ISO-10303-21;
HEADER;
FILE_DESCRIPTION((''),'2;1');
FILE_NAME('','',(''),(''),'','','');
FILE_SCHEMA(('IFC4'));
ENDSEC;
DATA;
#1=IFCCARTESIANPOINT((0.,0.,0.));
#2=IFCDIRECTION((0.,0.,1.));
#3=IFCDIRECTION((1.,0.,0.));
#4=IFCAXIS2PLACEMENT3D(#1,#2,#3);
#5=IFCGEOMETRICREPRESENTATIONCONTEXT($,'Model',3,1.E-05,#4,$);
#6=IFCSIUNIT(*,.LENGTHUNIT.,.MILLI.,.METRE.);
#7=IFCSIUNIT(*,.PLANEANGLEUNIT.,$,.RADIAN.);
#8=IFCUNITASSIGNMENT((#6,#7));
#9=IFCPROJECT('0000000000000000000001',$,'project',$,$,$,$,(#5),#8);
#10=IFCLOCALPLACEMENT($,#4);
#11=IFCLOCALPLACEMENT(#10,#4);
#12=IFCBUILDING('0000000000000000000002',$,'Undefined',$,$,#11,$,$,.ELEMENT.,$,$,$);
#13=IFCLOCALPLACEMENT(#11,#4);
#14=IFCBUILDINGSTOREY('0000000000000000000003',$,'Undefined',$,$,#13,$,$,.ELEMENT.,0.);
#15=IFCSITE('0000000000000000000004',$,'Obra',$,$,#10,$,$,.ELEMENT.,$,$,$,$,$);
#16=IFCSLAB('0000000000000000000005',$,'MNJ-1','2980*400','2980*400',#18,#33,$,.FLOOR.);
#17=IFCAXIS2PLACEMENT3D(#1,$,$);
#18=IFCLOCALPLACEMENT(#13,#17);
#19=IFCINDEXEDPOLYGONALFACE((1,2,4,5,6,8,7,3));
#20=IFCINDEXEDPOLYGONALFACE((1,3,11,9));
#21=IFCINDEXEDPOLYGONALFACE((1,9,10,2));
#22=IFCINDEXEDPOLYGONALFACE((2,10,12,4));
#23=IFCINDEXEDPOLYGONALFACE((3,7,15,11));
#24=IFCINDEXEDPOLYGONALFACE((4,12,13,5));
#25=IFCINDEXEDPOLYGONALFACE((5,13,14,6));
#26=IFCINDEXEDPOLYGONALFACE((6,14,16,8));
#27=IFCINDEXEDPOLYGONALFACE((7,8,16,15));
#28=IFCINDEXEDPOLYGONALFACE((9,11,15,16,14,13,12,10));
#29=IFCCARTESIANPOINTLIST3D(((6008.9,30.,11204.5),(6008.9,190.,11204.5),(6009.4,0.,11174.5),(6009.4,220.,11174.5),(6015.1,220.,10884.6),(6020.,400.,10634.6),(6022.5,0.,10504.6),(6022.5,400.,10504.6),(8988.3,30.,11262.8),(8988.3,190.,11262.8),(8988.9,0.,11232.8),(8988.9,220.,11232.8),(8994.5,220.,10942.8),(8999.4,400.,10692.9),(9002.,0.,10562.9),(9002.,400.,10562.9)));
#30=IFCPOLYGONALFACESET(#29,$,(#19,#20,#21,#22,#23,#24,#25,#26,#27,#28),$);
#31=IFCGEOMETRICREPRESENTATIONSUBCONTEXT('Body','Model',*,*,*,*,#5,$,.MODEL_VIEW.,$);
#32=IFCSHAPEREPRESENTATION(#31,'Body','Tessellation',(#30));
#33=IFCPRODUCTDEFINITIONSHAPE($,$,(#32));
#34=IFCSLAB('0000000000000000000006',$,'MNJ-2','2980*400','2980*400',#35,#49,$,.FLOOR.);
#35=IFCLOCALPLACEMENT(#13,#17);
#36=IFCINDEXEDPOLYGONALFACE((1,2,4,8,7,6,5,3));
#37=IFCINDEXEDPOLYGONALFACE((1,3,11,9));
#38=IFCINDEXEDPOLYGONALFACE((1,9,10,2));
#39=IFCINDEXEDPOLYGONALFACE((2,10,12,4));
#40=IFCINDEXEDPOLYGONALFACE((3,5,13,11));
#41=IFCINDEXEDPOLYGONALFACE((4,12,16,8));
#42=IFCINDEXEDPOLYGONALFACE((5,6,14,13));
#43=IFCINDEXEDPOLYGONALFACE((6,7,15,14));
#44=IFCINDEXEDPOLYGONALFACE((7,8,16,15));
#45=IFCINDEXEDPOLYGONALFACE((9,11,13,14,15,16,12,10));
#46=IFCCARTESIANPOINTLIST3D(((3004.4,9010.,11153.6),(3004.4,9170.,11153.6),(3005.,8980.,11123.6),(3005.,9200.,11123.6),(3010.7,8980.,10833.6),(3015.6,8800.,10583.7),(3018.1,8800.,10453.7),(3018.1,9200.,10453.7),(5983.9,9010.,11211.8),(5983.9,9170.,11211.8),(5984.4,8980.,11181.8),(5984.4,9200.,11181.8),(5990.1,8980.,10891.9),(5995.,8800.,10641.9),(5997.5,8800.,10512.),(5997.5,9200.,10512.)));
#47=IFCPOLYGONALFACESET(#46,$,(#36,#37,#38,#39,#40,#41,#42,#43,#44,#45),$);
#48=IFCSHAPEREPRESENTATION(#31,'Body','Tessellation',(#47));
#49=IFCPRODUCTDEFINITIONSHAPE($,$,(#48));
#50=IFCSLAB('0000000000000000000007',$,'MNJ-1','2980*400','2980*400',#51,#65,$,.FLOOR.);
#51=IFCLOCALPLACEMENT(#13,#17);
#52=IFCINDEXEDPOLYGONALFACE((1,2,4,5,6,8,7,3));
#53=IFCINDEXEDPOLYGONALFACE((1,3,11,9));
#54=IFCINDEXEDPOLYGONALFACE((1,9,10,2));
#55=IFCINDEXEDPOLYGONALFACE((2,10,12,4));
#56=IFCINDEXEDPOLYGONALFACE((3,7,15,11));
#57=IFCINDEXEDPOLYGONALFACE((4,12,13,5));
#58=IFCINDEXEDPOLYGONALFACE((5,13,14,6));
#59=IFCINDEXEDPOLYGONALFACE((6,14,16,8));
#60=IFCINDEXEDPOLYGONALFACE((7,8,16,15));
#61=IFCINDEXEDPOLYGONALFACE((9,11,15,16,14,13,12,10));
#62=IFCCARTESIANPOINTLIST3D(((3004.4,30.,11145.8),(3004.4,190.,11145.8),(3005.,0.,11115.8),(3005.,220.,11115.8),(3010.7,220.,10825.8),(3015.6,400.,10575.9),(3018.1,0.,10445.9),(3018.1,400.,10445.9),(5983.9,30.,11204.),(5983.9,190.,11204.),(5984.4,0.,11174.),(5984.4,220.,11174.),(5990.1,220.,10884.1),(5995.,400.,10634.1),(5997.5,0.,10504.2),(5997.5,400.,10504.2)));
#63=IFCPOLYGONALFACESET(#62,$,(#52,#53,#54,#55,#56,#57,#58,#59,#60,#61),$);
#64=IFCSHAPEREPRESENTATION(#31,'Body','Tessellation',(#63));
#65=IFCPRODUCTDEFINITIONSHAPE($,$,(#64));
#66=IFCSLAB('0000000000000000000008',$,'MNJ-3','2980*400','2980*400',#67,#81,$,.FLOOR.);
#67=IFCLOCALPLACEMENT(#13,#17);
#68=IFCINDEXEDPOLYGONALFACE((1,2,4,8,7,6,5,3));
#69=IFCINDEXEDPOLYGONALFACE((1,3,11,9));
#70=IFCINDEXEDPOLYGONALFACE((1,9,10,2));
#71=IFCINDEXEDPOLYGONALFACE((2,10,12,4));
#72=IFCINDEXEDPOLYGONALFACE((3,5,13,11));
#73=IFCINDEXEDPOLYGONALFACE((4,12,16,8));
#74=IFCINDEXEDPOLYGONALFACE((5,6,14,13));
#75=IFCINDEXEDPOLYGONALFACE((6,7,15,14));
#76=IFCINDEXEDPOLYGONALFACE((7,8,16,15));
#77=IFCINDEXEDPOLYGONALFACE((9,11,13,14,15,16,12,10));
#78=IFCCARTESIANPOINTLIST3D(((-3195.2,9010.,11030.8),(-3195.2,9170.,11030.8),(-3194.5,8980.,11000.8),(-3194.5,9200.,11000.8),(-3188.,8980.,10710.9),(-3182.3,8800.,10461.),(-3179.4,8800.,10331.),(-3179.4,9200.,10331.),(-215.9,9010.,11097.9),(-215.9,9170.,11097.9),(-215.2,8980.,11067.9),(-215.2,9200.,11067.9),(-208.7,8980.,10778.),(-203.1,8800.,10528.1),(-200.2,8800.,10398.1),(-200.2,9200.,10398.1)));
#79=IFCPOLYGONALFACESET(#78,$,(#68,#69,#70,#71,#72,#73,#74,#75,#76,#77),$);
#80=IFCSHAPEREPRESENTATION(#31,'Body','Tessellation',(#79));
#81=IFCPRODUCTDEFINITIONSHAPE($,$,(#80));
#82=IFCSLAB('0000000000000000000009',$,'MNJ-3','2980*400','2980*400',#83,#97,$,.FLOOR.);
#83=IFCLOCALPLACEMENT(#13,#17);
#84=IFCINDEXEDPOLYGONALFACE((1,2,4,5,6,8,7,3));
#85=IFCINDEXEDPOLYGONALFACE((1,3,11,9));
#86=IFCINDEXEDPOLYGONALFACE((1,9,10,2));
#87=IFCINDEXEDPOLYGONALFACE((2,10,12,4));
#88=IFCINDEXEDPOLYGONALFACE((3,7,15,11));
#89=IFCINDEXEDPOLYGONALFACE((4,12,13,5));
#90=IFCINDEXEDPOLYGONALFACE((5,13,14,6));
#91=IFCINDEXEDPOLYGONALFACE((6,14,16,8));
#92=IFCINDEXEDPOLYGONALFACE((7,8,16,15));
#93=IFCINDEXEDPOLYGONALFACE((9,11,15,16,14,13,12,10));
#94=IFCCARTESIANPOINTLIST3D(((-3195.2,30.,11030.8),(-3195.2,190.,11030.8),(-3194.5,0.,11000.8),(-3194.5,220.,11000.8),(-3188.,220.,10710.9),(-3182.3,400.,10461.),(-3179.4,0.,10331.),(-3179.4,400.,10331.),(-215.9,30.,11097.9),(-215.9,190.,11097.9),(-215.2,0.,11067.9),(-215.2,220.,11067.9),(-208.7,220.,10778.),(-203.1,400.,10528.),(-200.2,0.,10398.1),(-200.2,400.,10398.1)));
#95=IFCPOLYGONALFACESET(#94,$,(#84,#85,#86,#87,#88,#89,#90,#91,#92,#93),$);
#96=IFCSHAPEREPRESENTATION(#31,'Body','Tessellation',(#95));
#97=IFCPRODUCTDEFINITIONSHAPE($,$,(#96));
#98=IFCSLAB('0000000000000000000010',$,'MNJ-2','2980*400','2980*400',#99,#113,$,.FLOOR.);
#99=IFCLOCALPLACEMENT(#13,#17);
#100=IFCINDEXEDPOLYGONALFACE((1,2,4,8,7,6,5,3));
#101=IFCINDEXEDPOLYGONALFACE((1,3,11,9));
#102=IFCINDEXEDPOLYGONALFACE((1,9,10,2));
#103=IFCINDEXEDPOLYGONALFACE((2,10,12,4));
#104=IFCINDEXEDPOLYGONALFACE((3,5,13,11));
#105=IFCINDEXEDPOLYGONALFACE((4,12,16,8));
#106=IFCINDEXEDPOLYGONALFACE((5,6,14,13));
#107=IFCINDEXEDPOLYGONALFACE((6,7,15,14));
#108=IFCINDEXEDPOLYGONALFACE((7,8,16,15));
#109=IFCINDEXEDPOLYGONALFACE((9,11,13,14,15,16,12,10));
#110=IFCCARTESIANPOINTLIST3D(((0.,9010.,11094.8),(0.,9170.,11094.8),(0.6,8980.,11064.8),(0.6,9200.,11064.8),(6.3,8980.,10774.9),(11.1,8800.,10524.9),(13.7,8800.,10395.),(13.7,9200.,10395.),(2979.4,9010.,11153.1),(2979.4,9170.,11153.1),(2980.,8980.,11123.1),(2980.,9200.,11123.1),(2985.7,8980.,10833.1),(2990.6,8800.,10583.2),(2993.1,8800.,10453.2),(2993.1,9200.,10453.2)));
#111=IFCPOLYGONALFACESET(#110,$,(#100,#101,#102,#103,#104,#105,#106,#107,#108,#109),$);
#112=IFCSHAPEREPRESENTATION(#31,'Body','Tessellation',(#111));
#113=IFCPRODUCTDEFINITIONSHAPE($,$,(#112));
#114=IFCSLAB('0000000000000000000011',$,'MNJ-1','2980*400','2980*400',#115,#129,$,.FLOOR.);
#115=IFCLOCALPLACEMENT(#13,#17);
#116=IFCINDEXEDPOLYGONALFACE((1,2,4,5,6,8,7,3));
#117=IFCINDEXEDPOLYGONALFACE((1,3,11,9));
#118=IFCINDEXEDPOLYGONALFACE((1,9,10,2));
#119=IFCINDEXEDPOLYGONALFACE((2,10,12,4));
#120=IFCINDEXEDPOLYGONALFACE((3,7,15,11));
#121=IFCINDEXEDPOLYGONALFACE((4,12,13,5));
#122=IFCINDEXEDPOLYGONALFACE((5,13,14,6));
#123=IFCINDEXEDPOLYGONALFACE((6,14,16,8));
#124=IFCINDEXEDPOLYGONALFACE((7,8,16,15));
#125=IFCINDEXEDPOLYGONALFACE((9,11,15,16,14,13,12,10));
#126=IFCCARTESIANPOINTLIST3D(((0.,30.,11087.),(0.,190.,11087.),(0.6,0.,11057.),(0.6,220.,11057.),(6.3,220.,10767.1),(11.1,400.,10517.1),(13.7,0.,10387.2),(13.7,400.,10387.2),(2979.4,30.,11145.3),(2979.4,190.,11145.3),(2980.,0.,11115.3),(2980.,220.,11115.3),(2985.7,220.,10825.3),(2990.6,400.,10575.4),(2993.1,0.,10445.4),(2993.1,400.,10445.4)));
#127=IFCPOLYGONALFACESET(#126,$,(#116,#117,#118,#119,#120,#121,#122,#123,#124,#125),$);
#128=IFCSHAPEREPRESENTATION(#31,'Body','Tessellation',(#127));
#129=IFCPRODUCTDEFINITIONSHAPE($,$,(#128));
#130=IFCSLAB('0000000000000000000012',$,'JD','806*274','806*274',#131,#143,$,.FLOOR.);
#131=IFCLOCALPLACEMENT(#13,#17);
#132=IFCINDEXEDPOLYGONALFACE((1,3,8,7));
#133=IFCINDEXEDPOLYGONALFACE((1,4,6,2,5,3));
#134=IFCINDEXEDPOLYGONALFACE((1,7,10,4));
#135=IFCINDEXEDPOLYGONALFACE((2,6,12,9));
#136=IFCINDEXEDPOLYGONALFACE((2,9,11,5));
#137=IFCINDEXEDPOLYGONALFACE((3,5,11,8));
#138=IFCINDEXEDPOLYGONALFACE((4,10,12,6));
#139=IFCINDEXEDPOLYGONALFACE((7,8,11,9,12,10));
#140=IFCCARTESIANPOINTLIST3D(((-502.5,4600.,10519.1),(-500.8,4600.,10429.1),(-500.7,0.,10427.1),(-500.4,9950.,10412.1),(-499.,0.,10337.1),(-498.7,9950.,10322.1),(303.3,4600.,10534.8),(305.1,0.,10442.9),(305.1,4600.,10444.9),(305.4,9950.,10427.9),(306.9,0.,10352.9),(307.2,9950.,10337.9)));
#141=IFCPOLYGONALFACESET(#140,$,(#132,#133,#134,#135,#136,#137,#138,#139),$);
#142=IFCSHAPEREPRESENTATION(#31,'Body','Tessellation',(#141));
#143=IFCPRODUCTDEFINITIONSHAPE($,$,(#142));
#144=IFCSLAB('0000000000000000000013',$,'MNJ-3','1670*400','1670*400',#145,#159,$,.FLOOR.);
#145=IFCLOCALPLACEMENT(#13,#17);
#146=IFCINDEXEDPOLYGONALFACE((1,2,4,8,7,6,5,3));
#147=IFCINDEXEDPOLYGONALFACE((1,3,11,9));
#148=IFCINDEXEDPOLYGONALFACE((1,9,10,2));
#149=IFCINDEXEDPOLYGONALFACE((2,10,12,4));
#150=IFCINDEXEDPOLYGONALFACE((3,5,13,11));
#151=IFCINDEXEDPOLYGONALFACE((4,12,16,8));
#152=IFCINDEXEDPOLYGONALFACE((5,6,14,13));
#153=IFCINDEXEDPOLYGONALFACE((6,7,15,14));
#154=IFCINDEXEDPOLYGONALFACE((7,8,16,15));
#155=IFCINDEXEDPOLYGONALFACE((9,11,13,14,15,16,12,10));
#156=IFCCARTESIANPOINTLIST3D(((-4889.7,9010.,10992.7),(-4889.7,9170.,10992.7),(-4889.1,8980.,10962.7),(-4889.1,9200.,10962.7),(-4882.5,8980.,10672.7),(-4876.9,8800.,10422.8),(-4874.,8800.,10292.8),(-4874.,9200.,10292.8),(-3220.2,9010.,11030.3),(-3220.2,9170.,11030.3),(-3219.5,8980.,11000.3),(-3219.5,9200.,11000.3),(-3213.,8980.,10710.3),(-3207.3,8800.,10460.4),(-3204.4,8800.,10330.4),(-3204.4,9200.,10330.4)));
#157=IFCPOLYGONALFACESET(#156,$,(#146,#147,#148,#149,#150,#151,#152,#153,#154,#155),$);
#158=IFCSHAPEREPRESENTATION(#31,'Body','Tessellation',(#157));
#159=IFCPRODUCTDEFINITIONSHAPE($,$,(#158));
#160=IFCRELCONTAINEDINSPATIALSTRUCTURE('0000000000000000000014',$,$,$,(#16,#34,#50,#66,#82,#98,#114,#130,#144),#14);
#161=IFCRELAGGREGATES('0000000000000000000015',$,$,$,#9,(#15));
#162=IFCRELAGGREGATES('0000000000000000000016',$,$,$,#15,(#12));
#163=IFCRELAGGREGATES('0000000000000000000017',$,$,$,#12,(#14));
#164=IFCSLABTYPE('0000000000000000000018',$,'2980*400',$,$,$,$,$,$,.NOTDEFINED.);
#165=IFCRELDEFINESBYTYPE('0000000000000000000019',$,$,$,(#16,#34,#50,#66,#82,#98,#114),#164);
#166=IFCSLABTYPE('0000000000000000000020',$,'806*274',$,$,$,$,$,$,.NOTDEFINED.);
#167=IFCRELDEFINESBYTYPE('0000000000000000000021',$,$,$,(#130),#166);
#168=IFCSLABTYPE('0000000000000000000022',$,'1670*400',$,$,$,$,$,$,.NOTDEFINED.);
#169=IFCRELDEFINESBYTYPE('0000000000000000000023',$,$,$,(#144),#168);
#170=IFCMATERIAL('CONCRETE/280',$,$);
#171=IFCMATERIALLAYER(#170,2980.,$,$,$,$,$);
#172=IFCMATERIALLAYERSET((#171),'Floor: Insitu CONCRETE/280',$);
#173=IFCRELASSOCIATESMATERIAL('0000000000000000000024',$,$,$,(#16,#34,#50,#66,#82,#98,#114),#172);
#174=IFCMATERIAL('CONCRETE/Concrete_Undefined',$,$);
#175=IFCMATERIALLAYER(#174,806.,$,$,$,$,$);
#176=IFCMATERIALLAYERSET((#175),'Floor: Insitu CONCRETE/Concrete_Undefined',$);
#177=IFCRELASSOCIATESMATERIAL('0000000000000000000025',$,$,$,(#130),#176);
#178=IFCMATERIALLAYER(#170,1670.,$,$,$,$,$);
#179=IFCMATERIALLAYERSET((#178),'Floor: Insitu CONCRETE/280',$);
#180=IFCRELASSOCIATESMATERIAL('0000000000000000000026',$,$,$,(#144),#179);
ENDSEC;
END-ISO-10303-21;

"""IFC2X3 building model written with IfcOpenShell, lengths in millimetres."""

from ifc_helpers import new_model, si_unit, frame, origin_with_axes, place, context, subcontext, project, spatial, polyline, outline, extrude, material, layer, layer_set, layer_usage, type_object, element, save


model = new_model("IFC2X3")

# Units and contexts
model_context = context("Model", 3, precision=1e-05, world=origin_with_axes())
body_context = subcontext(model_context, "Body", "Model", "MODEL_VIEW")
ifc_project = project(units=[si_unit("LENGTHUNIT", "METRE", prefix="MILLI"), si_unit("PLANEANGLEUNIT", "RADIAN")], contexts=[model_context])

# Site, building, storey
site_placement = place(None, origin_with_axes())
site = spatial("IfcSite", under=ifc_project, at=site_placement, Name="Obra", CompositionType="ELEMENT")
building_placement = place(site_placement, origin_with_axes())
building = spatial("IfcBuilding", under=site, at=building_placement, Name="Undefined", CompositionType="ELEMENT")
storey_placement = place(building_placement, origin_with_axes())
storey = spatial("IfcBuildingStorey", under=building, at=storey_placement, Name="Undefined", CompositionType="ELEMENT", Elevation=0.0)

# Shared definitions
ifc_material_1 = material(Name="CONCRETE/280")

# Slabs
ifc_layer_1 = layer(ifc_material_1, 2980.0)
ifc_layer_set_1 = layer_set([ifc_layer_1], Name="Floor: Insitu CONCRETE/280")
slab_type_1 = type_object("IfcSlabType", Name="2980*400", PredefinedType="NOTDEFINED")
ifc_layer_usage_1 = layer_usage(ifc_layer_set_1, "AXIS3", "POSITIVE", -1490.0)
slab_1_placement = place(storey_placement, frame((7499.2, 0.0, 11203.6), z_axis=(0.999809, 0.0, 0.019547), x_axis=(0.019547, 0.0, -0.999809)))
element("IfcSlab", 1, at=slab_1_placement, inside=storey, type_object=slab_type_1, material=ifc_layer_usage_1, Name="MNJ-1", Description="2980*400", ObjectType="2980*400", PredefinedType="FLOOR", context=body_context, shape_type="SweptSolid", body=[
    extrude(outline(polyline([(0.0, 0.0), (670.0, 0.0), (670.0, 400.0), (540.0, 400.0), (290.0, 220.0), (0.0, 220.0), (-30.0, 190.0), (-30.0, 30.0), (0.0, 0.0)])), frame((0.0, 0.0, -1490.0), z_axis=(0.0, 0.0, 1.0), x_axis=(1.0, 0.0, 0.0)), (0.0, 0.0, 1.0), 2980.0),
])
ifc_layer_usage_2 = layer_usage(ifc_layer_set_1, "AXIS3", "POSITIVE", -1490.0)
slab_2_placement = place(storey_placement, frame((4494.7, 9200.0, 11152.7), z_axis=(-0.999809, 0.0, -0.019547), x_axis=(0.019547, 0.0, -0.999809)))
element("IfcSlab", 2, at=slab_2_placement, inside=storey, type_object=slab_type_1, material=ifc_layer_usage_2, Name="MNJ-2", Description="2980*400", ObjectType="2980*400", PredefinedType="FLOOR", context=body_context, shape_type="SweptSolid", body=[
    extrude(outline(polyline([(0.0, 0.0), (670.0, 0.0), (670.0, 400.0), (540.0, 400.0), (290.0, 220.0), (0.0, 220.0), (-30.0, 190.0), (-30.0, 30.0), (0.0, 0.0)])), frame((0.0, 0.0, -1490.0), z_axis=(0.0, 0.0, 1.0), x_axis=(1.0, 0.0, 0.0)), (0.0, 0.0, 1.0), 2980.0),
])
ifc_layer_usage_3 = layer_usage(ifc_layer_set_1, "AXIS3", "POSITIVE", -1490.0)
slab_3_placement = place(storey_placement, frame((4494.7, 0.0, 11144.9), z_axis=(0.999809, 0.0, 0.019547), x_axis=(0.019547, 0.0, -0.999809)))
element("IfcSlab", 3, at=slab_3_placement, inside=storey, type_object=slab_type_1, material=ifc_layer_usage_3, Name="MNJ-1", Description="2980*400", ObjectType="2980*400", PredefinedType="FLOOR", context=body_context, shape_type="SweptSolid", body=[
    extrude(outline(polyline([(0.0, 0.0), (670.0, 0.0), (670.0, 400.0), (540.0, 400.0), (290.0, 220.0), (0.0, 220.0), (-30.0, 190.0), (-30.0, 30.0), (0.0, 0.0)])), frame((0.0, 0.0, -1490.0), z_axis=(0.0, 0.0, 1.0), x_axis=(1.0, 0.0, 0.0)), (0.0, 0.0, 1.0), 2980.0),
])
ifc_layer_usage_4 = layer_usage(ifc_layer_set_1, "AXIS3", "POSITIVE", -1490.0)
slab_4_placement = place(storey_placement, frame((-1704.9, 9200.0, 11034.4), z_axis=(-0.999747, 0.0, -0.022513), x_axis=(0.022513, 0.0, -0.999747)))
element("IfcSlab", 4, at=slab_4_placement, inside=storey, type_object=slab_type_1, material=ifc_layer_usage_4, Name="MNJ-3", Description="2980*400", ObjectType="2980*400", PredefinedType="FLOOR", context=body_context, shape_type="SweptSolid", body=[
    extrude(outline(polyline([(0.0, 0.0), (670.0, 0.0), (670.0, 400.0), (540.0, 400.0), (290.0, 220.0), (0.0, 220.0), (-30.0, 190.0), (-30.0, 30.0), (0.0, 0.0)])), frame((0.0, 0.0, -1490.0), z_axis=(0.0, 0.0, 1.0), x_axis=(1.0, 0.0, 0.0)), (0.0, 0.0, 1.0), 2980.0),
])
ifc_layer_usage_5 = layer_usage(ifc_layer_set_1, "AXIS3", "POSITIVE", -1490.0)
slab_5_placement = place(storey_placement, frame((-1704.9, 0.0, 11034.4), z_axis=(0.999747, 0.0, 0.022513), x_axis=(0.022513, 0.0, -0.999747)))
element("IfcSlab", 5, at=slab_5_placement, inside=storey, type_object=slab_type_1, material=ifc_layer_usage_5, Name="MNJ-3", Description="2980*400", ObjectType="2980*400", PredefinedType="FLOOR", context=body_context, shape_type="SweptSolid", body=[
    extrude(outline(polyline([(0.0, 0.0), (670.0, 0.0), (670.0, 400.0), (540.0, 400.0), (290.0, 220.0), (0.0, 220.0), (-30.0, 190.0), (-30.0, 30.0), (0.0, 0.0)])), frame((0.0, 0.0, -1490.0), z_axis=(0.0, 0.0, 1.0), x_axis=(1.0, 0.0, 0.0)), (0.0, 0.0, 1.0), 2980.0),
])
ifc_layer_usage_6 = layer_usage(ifc_layer_set_1, "AXIS3", "POSITIVE", -1490.0)
slab_6_placement = place(storey_placement, frame((1490.3, 9200.0, 11094.0), z_axis=(-0.999809, 0.0, -0.019547), x_axis=(0.019547, 0.0, -0.999809)))
element("IfcSlab", 6, at=slab_6_placement, inside=storey, type_object=slab_type_1, material=ifc_layer_usage_6, Name="MNJ-2", Description="2980*400", ObjectType="2980*400", PredefinedType="FLOOR", context=body_context, shape_type="SweptSolid", body=[
    extrude(outline(polyline([(0.0, 0.0), (670.0, 0.0), (670.0, 400.0), (540.0, 400.0), (290.0, 220.0), (0.0, 220.0), (-30.0, 190.0), (-30.0, 30.0), (0.0, 0.0)])), frame((0.0, 0.0, -1490.0), z_axis=(0.0, 0.0, 1.0), x_axis=(1.0, 0.0, 0.0)), (0.0, 0.0, 1.0), 2980.0),
])
ifc_layer_usage_7 = layer_usage(ifc_layer_set_1, "AXIS3", "POSITIVE", -1490.0)
slab_7_placement = place(storey_placement, frame((1490.3, 0.0, 11086.2), z_axis=(0.999809, 0.0, 0.019547), x_axis=(0.019547, 0.0, -0.999809)))
element("IfcSlab", 7, at=slab_7_placement, inside=storey, type_object=slab_type_1, material=ifc_layer_usage_7, Name="MNJ-1", Description="2980*400", ObjectType="2980*400", PredefinedType="FLOOR", context=body_context, shape_type="SweptSolid", body=[
    extrude(outline(polyline([(0.0, 0.0), (670.0, 0.0), (670.0, 400.0), (540.0, 400.0), (290.0, 220.0), (0.0, 220.0), (-30.0, 190.0), (-30.0, 30.0), (0.0, 0.0)])), frame((0.0, 0.0, -1490.0), z_axis=(0.0, 0.0, 1.0), x_axis=(1.0, 0.0, 0.0)), (0.0, 0.0, 1.0), 2980.0),
])
ifc_material_2 = material(Name="CONCRETE/Concrete_Undefined")
ifc_layer_2 = layer(ifc_material_2, 806.0)
ifc_layer_set_2 = layer_set([ifc_layer_2], Name="Floor: Insitu CONCRETE/Concrete_Undefined")
ifc_layer_usage_8 = layer_usage(ifc_layer_set_2, "AXIS3", "POSITIVE", -403.0)
slab_type_2 = type_object("IfcSlabType", Name="806*274", PredefinedType="NOTDEFINED")
slab_8_placement = place(storey_placement, frame((-99.6, 4600.0, 10527.0), z_axis=(0.999809, 0.0, 0.019547), x_axis=(0.000391, -0.9998, -0.019992)))
element("IfcSlab", 8, at=slab_8_placement, inside=storey, type_object=slab_type_2, material=ifc_layer_usage_8, Name="JD", Description="806*274", ObjectType="806*274", PredefinedType="FLOOR", context=body_context, shape_type="SweptSolid", body=[
    extrude(outline(polyline([(0.0, 0.0), (4600.9, 0.0), (4602.7, 90.0), (1.8, 90.0), (-5345.0, 303.9), (-5346.8, 214.0), (0.0, 0.0)])), frame((0.0, 0.0, -403.0), z_axis=(0.0, 0.0, 1.0), x_axis=(1.0, 0.0, 0.0)), (0.0, 0.0, 1.0), 806.0),
])
ifc_layer_3 = layer(ifc_material_1, 1670.0)
ifc_layer_set_3 = layer_set([ifc_layer_3], Name="Floor: Insitu CONCRETE/280")
ifc_layer_usage_9 = layer_usage(ifc_layer_set_3, "AXIS3", "POSITIVE", -835.0)
slab_type_3 = type_object("IfcSlabType", Name="1670*400", PredefinedType="NOTDEFINED")
slab_9_placement = place(storey_placement, frame((-4054.3, 9200.0, 10981.5), z_axis=(-0.999747, 0.0, -0.022513), x_axis=(0.022513, 0.0, -0.999747)))
element("IfcSlab", 9, at=slab_9_placement, inside=storey, type_object=slab_type_3, material=ifc_layer_usage_9, Name="MNJ-3", Description="1670*400", ObjectType="1670*400", PredefinedType="FLOOR", context=body_context, shape_type="SweptSolid", body=[
    extrude(outline(polyline([(0.0, 0.0), (670.0, 0.0), (670.0, 400.0), (540.0, 400.0), (290.0, 220.0), (0.0, 220.0), (-30.0, 190.0), (-30.0, 30.0), (0.0, 0.0)])), frame((0.0, 0.0, -835.0), z_axis=(0.0, 0.0, 1.0), x_axis=(1.0, 0.0, 0.0)), (0.0, 0.0, 1.0), 1670.0),
])

save(model, "model.ifc")
